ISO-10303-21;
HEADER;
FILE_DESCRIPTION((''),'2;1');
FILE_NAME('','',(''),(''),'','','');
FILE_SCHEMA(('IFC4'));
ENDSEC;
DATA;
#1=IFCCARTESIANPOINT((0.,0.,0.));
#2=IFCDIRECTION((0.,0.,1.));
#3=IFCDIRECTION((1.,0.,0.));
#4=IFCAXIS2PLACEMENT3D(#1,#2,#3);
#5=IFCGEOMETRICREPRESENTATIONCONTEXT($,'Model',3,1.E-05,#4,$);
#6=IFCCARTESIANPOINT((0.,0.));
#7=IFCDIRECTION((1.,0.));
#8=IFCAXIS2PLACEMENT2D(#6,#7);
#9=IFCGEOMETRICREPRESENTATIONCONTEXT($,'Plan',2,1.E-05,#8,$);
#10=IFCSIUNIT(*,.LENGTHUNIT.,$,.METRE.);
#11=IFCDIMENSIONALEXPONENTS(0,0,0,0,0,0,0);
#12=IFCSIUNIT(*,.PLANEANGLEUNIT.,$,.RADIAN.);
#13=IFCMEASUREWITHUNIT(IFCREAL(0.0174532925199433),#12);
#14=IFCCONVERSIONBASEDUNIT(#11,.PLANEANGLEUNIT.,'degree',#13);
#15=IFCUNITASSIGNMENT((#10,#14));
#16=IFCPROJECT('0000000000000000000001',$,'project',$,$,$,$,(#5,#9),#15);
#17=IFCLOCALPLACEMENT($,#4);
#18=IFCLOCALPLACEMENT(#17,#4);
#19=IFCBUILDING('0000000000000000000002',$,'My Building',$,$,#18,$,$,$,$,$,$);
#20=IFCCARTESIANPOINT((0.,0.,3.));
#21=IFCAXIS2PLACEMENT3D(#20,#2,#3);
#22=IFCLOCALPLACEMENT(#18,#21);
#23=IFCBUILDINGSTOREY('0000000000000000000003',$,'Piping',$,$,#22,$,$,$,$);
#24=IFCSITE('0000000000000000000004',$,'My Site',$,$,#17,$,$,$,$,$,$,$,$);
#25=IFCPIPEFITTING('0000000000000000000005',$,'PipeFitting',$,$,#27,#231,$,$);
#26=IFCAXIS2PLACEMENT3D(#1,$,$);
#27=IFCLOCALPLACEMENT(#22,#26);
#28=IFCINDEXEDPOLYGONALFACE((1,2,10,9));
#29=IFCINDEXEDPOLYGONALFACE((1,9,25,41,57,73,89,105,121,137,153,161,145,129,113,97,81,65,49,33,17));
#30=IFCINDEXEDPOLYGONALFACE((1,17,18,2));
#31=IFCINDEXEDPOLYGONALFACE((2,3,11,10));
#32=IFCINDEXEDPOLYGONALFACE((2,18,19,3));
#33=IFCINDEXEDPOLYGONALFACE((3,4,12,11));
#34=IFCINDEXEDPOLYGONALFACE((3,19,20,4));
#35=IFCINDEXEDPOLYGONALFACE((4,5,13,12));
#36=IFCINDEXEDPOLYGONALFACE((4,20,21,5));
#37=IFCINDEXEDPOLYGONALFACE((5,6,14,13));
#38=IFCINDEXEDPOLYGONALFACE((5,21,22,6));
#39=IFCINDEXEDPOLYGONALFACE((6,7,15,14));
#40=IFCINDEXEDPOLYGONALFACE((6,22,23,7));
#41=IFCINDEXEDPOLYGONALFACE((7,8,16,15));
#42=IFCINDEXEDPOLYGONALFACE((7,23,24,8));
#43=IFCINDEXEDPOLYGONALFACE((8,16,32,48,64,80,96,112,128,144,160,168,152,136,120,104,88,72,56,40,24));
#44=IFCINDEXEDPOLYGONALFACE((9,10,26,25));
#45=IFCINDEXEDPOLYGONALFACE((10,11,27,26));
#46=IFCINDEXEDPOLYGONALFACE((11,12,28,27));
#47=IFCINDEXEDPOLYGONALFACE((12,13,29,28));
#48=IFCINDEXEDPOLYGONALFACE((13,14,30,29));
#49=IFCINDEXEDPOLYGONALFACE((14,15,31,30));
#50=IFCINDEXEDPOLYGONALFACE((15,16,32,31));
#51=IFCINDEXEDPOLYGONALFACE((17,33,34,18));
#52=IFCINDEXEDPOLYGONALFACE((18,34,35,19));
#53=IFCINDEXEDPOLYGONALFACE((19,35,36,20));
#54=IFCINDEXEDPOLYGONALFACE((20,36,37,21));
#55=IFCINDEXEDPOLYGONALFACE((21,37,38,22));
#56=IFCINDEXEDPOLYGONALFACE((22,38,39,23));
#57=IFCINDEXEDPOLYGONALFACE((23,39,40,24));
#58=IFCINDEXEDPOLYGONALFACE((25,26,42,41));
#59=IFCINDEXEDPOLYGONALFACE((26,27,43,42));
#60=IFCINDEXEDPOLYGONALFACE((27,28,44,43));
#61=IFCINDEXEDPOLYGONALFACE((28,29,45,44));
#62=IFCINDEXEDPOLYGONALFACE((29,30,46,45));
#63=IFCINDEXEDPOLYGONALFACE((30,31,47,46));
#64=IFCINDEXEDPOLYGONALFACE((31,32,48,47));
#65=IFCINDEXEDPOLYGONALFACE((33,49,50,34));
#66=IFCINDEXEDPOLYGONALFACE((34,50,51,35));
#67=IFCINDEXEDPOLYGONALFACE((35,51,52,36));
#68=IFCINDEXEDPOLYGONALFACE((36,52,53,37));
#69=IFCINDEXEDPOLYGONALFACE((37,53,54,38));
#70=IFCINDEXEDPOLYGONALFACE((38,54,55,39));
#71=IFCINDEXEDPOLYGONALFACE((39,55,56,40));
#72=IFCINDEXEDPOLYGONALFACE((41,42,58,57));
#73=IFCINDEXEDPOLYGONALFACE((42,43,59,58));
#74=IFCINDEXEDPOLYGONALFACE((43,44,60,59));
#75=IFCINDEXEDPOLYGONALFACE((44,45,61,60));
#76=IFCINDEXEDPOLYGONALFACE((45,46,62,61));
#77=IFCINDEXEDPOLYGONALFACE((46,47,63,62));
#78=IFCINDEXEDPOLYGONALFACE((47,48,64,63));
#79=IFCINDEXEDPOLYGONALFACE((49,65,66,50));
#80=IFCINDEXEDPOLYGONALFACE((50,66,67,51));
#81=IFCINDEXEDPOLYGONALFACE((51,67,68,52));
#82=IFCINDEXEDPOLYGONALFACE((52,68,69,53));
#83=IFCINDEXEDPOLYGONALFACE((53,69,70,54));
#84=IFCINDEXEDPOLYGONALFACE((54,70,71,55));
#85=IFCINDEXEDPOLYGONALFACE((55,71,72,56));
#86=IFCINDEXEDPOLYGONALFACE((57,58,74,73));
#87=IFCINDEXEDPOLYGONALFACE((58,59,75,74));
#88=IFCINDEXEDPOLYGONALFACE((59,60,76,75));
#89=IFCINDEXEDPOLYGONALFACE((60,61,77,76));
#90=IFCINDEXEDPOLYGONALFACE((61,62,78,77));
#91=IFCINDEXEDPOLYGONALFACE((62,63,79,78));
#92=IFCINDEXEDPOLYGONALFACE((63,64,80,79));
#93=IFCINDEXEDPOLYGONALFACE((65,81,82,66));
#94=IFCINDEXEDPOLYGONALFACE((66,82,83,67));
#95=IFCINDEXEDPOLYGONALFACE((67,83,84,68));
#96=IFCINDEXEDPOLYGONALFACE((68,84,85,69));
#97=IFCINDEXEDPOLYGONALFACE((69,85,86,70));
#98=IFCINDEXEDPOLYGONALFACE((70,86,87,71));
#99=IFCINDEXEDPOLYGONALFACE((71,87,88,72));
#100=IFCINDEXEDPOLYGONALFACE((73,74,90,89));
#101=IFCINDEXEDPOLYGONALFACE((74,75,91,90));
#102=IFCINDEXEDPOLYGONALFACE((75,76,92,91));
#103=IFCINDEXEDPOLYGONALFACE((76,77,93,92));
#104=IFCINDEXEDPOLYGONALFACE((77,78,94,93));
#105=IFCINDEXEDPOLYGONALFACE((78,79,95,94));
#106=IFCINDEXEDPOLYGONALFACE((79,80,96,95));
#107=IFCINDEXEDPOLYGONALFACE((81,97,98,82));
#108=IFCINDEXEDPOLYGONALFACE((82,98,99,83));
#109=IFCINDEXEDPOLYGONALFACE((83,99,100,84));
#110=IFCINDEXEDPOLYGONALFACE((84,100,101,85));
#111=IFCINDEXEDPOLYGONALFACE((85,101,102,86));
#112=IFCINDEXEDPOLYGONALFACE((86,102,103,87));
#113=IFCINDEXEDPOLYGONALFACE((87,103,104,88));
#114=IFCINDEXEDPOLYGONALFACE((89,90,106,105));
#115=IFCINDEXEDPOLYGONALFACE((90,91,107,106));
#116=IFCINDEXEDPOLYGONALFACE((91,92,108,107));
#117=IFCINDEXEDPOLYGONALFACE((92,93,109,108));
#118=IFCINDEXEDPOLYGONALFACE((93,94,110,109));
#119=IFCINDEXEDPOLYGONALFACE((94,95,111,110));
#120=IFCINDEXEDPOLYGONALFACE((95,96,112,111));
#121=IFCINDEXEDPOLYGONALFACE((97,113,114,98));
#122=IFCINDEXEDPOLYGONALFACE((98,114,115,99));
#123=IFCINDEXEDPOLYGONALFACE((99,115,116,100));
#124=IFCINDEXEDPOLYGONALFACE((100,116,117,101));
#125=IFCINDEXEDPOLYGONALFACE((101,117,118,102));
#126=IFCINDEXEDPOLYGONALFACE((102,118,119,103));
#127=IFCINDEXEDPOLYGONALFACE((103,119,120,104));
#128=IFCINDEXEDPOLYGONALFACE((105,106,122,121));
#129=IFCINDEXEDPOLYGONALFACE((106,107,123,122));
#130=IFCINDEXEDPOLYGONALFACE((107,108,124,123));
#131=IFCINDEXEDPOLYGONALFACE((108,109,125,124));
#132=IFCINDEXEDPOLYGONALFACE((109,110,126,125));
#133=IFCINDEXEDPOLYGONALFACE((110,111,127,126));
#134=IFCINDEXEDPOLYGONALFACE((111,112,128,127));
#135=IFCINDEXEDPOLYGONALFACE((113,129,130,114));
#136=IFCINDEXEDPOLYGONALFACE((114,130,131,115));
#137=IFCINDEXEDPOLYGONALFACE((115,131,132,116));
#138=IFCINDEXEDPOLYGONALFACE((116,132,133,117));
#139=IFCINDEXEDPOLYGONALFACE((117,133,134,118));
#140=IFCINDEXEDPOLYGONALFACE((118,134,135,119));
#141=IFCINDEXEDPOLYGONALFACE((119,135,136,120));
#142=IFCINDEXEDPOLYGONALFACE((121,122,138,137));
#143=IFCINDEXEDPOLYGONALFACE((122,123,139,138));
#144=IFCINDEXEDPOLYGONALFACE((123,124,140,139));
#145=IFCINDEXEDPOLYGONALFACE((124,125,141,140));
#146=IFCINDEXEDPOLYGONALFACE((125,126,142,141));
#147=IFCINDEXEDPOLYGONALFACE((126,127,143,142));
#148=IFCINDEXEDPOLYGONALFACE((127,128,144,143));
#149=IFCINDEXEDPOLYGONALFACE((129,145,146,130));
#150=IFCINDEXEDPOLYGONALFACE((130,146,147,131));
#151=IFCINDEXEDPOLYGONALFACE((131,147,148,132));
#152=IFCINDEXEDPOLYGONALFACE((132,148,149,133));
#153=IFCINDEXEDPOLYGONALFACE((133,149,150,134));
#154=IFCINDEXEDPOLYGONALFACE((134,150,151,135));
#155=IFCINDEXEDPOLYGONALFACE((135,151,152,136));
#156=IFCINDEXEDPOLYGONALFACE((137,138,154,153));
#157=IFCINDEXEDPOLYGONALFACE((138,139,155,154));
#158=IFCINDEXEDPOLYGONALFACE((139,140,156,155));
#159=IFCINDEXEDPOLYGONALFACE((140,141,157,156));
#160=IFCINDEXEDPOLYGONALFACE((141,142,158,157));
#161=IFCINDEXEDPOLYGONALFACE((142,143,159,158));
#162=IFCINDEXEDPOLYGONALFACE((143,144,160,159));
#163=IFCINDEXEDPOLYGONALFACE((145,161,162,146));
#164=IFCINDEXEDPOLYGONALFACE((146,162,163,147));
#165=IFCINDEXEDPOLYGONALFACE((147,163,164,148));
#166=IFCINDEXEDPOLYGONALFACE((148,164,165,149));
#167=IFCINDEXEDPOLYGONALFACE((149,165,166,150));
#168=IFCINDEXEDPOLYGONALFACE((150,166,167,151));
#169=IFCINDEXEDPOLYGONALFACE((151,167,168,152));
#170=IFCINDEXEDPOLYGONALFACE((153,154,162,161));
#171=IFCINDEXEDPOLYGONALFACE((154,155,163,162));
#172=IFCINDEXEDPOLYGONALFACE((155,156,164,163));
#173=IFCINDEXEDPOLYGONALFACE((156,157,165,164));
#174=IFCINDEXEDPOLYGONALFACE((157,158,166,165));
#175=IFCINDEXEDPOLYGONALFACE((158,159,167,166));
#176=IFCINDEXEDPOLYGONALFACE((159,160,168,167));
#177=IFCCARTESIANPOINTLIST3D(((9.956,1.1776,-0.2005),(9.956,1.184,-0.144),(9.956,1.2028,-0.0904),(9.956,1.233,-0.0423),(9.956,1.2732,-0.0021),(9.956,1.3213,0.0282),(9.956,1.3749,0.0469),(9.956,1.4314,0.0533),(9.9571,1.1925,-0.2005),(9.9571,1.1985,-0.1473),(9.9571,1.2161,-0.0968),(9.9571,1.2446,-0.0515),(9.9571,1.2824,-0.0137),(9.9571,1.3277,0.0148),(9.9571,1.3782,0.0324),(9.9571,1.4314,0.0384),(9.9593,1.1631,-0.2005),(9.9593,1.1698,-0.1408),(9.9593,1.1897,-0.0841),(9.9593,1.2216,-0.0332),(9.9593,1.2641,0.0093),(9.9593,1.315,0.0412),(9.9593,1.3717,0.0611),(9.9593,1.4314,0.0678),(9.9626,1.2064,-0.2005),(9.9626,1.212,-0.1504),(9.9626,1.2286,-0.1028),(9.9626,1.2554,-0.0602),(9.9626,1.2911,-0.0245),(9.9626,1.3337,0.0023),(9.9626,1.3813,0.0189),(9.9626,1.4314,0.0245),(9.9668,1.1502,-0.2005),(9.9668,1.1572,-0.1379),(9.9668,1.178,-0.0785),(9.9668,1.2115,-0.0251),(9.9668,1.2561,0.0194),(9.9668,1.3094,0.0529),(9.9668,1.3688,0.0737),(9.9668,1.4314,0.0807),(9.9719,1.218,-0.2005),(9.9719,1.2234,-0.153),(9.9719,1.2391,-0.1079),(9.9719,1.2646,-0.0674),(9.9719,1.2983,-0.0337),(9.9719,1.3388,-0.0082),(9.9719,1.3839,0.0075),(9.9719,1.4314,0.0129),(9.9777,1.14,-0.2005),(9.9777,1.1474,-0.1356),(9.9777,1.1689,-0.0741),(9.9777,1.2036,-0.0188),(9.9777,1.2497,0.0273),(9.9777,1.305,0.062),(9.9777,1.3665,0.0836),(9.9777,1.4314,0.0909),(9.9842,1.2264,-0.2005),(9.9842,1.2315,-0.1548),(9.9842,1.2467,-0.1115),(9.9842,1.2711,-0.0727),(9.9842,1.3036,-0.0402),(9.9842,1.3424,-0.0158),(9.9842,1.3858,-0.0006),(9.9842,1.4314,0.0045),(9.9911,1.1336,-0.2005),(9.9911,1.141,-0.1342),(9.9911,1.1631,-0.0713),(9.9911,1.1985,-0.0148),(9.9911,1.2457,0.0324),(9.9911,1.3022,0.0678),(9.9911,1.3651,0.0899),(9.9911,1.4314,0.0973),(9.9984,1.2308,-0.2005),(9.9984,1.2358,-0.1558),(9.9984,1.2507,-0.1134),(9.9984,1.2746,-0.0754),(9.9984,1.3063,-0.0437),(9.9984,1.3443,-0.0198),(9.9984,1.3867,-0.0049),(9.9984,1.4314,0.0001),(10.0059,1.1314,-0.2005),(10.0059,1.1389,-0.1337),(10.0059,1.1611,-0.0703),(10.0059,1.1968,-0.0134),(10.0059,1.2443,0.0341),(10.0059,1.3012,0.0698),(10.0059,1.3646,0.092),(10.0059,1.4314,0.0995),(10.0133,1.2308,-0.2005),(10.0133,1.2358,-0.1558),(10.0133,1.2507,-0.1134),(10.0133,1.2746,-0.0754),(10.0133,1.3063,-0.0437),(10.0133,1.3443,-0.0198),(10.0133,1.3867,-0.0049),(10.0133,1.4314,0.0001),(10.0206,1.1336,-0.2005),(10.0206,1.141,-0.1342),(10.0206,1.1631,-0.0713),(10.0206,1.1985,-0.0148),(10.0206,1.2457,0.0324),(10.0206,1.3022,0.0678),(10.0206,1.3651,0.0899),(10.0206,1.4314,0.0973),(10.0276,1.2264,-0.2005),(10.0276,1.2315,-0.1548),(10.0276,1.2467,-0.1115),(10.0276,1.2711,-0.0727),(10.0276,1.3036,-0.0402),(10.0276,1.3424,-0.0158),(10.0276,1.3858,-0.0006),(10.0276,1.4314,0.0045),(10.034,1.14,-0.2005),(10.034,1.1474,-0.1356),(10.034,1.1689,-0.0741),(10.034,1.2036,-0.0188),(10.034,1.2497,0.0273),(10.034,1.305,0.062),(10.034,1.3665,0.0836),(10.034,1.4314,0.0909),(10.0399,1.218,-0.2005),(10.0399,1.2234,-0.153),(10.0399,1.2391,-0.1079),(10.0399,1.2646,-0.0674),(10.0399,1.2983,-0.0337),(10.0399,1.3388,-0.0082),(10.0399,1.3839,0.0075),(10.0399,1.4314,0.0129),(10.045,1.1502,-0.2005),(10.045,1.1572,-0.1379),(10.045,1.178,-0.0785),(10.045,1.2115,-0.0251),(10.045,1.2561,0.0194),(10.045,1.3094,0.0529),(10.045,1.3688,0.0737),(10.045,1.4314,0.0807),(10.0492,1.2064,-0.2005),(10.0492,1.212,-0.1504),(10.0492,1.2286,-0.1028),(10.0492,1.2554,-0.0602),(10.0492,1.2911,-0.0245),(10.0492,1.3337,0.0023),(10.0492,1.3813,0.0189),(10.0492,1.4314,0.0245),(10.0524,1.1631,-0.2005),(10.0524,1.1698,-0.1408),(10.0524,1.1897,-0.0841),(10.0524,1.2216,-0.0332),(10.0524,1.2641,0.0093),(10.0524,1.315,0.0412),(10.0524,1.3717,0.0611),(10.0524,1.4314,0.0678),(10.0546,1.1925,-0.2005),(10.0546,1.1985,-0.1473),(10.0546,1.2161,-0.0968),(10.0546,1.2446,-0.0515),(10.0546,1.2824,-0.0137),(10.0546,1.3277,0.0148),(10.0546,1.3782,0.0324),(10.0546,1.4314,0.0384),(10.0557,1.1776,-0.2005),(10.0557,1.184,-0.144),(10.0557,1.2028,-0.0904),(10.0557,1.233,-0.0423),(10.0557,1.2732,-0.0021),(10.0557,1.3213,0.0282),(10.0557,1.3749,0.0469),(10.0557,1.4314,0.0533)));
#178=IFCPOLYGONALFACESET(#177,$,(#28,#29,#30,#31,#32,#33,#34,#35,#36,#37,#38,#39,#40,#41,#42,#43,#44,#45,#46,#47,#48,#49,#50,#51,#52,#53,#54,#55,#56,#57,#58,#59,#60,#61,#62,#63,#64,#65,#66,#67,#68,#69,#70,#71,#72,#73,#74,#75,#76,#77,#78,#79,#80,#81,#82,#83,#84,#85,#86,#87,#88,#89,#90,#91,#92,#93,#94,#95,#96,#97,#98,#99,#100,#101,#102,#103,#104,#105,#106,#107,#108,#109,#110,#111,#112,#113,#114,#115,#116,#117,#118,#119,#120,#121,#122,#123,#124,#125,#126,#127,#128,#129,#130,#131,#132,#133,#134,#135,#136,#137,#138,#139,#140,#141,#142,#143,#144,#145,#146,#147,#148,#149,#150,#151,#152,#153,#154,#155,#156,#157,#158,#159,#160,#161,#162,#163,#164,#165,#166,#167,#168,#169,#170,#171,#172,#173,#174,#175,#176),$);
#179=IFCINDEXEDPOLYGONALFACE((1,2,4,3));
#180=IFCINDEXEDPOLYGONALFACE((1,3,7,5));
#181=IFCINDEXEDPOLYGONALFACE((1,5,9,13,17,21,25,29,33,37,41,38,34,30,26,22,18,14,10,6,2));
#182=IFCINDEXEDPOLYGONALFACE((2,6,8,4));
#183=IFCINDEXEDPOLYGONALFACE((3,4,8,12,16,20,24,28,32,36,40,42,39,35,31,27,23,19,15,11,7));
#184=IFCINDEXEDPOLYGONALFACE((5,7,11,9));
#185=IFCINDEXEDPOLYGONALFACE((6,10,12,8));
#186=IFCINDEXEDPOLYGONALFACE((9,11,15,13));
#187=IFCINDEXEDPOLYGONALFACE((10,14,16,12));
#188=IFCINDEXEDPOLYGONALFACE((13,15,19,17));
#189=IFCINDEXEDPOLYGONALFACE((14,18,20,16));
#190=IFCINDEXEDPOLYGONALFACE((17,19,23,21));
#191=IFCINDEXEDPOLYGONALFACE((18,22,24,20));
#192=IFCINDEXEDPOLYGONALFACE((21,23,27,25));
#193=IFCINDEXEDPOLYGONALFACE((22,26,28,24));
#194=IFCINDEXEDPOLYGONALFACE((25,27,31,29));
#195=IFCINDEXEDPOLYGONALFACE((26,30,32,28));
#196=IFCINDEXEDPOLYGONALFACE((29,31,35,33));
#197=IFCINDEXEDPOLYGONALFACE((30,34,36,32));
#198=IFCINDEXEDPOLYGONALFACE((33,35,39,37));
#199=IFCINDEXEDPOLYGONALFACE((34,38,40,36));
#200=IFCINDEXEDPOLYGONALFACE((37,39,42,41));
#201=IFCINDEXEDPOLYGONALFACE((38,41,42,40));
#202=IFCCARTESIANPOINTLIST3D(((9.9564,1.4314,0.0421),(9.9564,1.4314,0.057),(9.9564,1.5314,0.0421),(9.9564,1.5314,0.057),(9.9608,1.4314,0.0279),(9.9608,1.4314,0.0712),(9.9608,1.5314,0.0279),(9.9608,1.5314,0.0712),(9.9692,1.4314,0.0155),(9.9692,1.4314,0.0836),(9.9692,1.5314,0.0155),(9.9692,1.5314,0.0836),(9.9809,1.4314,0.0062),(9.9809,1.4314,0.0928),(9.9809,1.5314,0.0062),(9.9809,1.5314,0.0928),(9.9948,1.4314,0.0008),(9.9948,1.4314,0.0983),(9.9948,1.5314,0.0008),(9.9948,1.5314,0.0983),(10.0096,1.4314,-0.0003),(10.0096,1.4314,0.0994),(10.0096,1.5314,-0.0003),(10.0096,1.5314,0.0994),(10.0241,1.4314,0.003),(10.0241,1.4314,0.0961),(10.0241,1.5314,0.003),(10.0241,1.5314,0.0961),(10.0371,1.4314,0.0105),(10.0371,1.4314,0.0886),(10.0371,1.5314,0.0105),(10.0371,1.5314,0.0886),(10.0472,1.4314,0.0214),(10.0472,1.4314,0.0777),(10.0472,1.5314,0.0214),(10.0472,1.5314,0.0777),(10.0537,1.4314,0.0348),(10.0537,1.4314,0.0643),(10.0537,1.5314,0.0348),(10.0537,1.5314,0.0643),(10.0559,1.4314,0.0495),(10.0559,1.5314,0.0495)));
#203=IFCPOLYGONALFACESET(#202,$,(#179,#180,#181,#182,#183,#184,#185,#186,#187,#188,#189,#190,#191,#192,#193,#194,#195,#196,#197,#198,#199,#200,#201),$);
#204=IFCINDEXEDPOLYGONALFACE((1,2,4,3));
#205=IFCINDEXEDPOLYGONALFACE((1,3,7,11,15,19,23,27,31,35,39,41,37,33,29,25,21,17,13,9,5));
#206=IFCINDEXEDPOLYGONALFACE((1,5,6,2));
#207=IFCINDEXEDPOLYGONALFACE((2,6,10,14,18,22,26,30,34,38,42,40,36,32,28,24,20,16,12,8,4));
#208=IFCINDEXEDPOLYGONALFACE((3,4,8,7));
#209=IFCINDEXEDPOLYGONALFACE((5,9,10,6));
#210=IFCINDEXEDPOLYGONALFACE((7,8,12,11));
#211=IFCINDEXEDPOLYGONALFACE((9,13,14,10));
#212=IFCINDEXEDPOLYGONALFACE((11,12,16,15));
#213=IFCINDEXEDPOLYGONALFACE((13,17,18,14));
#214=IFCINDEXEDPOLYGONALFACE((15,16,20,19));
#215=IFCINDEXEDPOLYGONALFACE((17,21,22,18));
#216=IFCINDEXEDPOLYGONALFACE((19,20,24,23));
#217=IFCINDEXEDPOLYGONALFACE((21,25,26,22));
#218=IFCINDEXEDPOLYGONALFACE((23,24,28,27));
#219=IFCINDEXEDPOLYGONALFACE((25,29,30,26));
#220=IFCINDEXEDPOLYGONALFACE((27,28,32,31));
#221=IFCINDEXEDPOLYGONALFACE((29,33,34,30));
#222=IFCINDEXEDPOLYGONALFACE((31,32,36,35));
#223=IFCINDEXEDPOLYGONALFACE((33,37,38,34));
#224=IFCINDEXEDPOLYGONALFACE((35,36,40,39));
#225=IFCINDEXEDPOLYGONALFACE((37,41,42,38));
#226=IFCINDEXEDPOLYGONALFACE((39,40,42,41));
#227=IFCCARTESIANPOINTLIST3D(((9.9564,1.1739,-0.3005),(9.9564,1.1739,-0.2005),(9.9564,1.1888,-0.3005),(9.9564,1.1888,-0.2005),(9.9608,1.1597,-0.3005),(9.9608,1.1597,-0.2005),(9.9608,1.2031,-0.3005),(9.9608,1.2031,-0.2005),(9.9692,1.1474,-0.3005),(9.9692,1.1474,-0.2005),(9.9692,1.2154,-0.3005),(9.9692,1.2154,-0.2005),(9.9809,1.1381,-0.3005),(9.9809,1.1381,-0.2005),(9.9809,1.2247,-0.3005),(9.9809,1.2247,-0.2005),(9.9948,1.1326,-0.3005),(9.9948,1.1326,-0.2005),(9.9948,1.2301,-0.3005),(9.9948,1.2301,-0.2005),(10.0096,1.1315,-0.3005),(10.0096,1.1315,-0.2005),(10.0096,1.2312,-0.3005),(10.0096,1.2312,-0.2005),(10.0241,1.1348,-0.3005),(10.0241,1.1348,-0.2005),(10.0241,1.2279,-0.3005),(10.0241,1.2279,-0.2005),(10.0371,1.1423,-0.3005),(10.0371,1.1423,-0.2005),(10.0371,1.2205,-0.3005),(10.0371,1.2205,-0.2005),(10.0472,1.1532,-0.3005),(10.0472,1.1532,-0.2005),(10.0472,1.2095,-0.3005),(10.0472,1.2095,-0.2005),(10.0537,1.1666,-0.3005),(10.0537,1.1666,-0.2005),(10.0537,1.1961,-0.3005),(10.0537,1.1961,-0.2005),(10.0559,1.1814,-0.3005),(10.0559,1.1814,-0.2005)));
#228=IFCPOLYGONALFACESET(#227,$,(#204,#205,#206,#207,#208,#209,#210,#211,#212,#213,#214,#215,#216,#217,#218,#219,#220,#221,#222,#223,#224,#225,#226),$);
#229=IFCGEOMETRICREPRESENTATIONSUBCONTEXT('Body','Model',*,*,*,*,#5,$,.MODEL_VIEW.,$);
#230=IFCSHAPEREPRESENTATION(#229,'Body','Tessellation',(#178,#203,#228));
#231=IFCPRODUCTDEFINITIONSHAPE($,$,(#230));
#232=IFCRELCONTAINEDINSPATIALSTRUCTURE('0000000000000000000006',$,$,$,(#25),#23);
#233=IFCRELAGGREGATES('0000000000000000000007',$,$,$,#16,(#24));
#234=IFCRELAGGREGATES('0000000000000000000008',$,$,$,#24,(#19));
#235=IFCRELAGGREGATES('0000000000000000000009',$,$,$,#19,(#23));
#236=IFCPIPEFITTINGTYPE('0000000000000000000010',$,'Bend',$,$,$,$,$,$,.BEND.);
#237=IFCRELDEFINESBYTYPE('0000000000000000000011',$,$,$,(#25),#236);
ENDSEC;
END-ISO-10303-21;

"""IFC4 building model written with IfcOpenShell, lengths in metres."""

from ifc_helpers import new_model, entity, si_unit, converted_unit, frame, origin_with_axes, origin_2d_with_axis, place, context, subcontext, project, spatial, circle, extrude, source, transform, mapped, type_object, type_shapes, element, save


model = new_model("IFC4")

# Units and contexts
model_context = context("Model", 3, precision=1e-05, world=origin_with_axes())
plan_context = context("Plan", 2, precision=1e-05, world=origin_2d_with_axis())
body_context = subcontext(model_context, "Body", "Model", "MODEL_VIEW")
ifc_project = project(units=[si_unit("LENGTHUNIT", "METRE"), converted_unit("PLANEANGLEUNIT", "degree", entity("IfcReal", 0.0174532925199433), si_unit("PLANEANGLEUNIT", "RADIAN"), dimensions=[0, 0, 0, 0, 0, 0, 0])], contexts=[model_context, plan_context])

# Site, building, storey
site_placement = place(None, origin_with_axes())
site = spatial("IfcSite", under=ifc_project, at=site_placement, Name="My Site")
building_placement = place(site_placement, origin_with_axes())
building = spatial("IfcBuilding", under=site, at=building_placement, Name="My Building")
storey_placement = place(building_placement, frame((0.0, 0.0, 3.0), z_axis=(0.0, 0.0, 1.0), x_axis=(1.0, 0.0, 0.0)))
storey = spatial("IfcBuildingStorey", under=building, at=storey_placement, Name="Piping")

# Pipe fitting
pipe_fitting_type = type_object("IfcPipeFittingType", Name="Bend", PredefinedType="BEND")
shared_shape = source(origin_with_axes(), body_context, "Body", "SolidModel", [
    entity("IfcSweptDiskSolid", entity("IfcIndexedPolyCurve", entity("IfcCartesianPointList3D", [[0.0, 0.0, 0.1], [0.0, -0.0732, 0.2768], [0.0, -0.25, 0.35]]), [entity("IfcArcIndex", [1, 2, 3])]), 0.05),
    extrude(circle(Radius=0.05), origin_with_axes(), (0.0, 0.0, 1.0), 0.1),
    extrude(circle(Radius=0.05), frame((0.0, -0.25, 0.35), z_axis=(0.0, -1.0, 0.0), x_axis=(1.0, 0.0, 0.0)), (0.0, 0.0, 1.0), 0.1),
])
type_shapes(pipe_fitting_type, [shared_shape])
for number, where, z_axis, x_axis, name in (
    (1, (10.0059, 1.5314, 0.0495), (0.0, -1.0, 0.0), (1.0, 0.0, 0.0), "PipeFitting"),
):
    element("IfcPipeFitting", number, at=place(storey_placement, frame(where, z_axis=z_axis, x_axis=x_axis)), inside=storey, type_object=pipe_fitting_type, Name=name, context=body_context, shape_type="MappedRepresentation", body=[
        mapped(shared_shape, transform((0.0, 0.0, 0.0), x_axis=(1.0, 0.0, 0.0), y_axis=(0.0, 1.0, 0.0), z_axis=(0.0, 0.0, 1.0), scale=1.0)),
    ])

save(model, "model.ifc")
